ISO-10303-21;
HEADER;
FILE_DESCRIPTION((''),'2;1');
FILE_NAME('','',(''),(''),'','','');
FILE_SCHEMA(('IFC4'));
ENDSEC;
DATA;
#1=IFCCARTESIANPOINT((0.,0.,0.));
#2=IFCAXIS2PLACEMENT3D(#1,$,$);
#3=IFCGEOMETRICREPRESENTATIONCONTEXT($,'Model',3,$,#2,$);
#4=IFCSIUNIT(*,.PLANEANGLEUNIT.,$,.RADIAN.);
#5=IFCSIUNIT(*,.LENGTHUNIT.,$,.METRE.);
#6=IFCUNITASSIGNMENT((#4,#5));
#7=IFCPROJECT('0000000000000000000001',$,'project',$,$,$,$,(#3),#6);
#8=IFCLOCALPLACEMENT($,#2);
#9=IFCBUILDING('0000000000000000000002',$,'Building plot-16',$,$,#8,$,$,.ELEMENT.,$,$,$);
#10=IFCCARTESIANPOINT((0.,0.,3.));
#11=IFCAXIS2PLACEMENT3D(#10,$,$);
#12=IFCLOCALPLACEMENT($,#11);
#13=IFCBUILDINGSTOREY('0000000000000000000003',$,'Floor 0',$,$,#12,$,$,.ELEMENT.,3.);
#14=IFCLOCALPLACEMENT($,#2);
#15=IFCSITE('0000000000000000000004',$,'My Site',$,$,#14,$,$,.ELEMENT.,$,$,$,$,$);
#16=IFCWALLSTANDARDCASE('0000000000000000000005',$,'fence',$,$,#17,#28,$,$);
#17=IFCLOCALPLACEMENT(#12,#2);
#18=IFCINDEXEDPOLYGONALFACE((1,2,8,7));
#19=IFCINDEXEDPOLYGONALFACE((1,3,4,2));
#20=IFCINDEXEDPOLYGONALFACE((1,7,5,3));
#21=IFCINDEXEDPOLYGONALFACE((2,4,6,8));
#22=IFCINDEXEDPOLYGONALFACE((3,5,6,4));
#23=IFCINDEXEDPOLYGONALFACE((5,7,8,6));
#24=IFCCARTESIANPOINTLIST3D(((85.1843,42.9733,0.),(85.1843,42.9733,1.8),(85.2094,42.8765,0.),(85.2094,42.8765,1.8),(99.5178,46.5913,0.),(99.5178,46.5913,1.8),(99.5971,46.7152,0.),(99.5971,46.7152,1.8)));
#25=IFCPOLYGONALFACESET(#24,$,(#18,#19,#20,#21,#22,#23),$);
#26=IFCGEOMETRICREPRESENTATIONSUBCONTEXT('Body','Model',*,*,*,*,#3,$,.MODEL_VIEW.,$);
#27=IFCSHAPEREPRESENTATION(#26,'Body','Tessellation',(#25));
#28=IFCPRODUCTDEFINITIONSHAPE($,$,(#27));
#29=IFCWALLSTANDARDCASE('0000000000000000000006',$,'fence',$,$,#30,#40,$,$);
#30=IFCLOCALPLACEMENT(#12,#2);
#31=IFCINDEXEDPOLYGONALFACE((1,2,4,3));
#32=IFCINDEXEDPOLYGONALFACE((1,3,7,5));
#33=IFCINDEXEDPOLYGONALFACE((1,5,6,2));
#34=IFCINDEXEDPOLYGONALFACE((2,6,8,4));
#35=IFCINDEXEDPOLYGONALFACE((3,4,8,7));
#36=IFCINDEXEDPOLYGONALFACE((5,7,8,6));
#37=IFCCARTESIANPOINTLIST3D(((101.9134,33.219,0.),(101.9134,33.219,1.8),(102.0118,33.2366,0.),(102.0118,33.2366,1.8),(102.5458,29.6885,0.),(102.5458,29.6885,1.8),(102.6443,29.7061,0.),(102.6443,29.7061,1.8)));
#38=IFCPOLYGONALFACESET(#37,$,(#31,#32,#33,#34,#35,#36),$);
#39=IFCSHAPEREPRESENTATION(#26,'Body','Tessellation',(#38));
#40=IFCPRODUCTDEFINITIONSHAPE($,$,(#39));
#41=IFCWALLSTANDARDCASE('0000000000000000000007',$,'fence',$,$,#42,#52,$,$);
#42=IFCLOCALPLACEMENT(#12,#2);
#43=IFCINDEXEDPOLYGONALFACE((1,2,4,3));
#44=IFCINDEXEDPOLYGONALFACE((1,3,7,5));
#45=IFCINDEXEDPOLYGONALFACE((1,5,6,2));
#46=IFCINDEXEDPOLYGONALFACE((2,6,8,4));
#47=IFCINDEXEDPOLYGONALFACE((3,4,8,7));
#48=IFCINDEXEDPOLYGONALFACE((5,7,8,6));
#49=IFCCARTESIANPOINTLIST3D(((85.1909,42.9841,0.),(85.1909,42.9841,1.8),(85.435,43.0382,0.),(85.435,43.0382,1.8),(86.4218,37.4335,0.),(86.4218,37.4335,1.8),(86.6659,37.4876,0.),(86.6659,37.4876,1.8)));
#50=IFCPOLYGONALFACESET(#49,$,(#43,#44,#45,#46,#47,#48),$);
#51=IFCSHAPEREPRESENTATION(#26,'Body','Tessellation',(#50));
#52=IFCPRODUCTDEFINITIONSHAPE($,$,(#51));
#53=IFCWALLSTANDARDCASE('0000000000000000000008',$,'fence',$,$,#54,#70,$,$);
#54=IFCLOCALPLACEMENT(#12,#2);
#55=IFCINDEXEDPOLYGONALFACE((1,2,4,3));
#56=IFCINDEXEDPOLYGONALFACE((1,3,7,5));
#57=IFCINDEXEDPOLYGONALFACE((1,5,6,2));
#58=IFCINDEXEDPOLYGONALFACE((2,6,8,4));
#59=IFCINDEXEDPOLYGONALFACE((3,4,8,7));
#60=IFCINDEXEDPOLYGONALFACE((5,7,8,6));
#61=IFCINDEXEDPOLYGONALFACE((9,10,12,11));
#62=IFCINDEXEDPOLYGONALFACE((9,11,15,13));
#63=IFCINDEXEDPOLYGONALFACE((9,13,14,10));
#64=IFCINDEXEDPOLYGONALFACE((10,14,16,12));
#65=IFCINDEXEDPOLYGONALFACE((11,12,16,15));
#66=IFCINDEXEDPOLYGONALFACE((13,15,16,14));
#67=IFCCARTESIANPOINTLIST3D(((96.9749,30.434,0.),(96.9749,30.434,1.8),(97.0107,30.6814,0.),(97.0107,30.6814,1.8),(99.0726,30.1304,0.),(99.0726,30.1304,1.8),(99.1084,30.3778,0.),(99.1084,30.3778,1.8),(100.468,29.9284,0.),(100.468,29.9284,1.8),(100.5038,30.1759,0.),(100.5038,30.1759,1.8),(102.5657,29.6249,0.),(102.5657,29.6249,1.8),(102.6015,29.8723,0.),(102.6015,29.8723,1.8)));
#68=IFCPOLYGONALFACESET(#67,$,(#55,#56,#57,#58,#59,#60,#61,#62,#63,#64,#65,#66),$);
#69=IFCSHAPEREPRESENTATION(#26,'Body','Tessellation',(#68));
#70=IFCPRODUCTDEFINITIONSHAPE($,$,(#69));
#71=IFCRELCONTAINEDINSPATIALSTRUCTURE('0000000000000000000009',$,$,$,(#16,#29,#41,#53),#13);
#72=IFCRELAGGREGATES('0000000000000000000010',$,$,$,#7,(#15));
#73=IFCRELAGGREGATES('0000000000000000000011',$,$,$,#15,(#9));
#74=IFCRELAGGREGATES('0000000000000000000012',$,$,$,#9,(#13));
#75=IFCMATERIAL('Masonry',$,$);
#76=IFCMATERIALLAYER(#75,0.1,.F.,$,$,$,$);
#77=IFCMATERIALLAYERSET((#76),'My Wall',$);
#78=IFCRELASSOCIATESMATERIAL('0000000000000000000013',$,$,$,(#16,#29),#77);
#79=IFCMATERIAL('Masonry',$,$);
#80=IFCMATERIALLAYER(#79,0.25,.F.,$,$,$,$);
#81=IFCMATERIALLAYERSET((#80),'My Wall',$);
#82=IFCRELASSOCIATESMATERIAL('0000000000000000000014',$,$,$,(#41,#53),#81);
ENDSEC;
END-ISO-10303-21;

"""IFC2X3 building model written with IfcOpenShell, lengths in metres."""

from ifc_helpers import new_model, si_unit, frame, origin, place, context, subcontext, project, spatial, polyline, outline, extrude, material, layer, layer_set, layer_usage, element, save


model = new_model("IFC2X3")

# Units and contexts
model_context = context("Model", 3, world=origin())
body_context = subcontext(model_context, "Body", "Model", "MODEL_VIEW")
ifc_project = project(units=[si_unit("PLANEANGLEUNIT", "RADIAN"), si_unit("LENGTHUNIT", "METRE")], contexts=[model_context])

# Site, building, storey
site_placement = place(None, origin())
site = spatial("IfcSite", under=ifc_project, at=site_placement, Name="My Site", CompositionType="ELEMENT")
building_placement = place(None, origin())
building = spatial("IfcBuilding", under=site, at=building_placement, Name="Building plot-16", CompositionType="ELEMENT")
storey_placement = place(None, frame((0.0, 0.0, 3.0)))
storey = spatial("IfcBuildingStorey", under=building, at=storey_placement, Name="Floor 0", CompositionType="ELEMENT", Elevation=3.0)

# Walls
ifc_material_1 = material(Name="Masonry")
ifc_layer_1 = layer(ifc_material_1, 0.1, ventilated=False)
ifc_layer_set_1 = layer_set([ifc_layer_1], Name="My Wall")
ifc_layer_usage_1 = layer_usage(ifc_layer_set_1, "AXIS2", "NEGATIVE", -0.15)
wall_1_placement = place(storey_placement, origin())
element("IfcWallStandardCase", 1, at=wall_1_placement, inside=storey, material=ifc_layer_usage_1, Name="fence", context=body_context, shape_type="SweptSolid", body=[
    extrude(outline(polyline([(99.5178, 46.5913), (99.5971, 46.7152), (85.1843, 42.9733), (85.2094, 42.8765), (99.5178, 46.5913)])), origin(), (0.0, 0.0, 1.0), 1.8),
])
wall_2_placement = place(storey_placement, origin())
element("IfcWallStandardCase", 2, at=wall_2_placement, inside=storey, material=ifc_layer_usage_1, Name="fence", context=body_context, shape_type="SweptSolid", body=[
    extrude(outline(polyline([(102.5458, 29.6885), (102.6443, 29.7061), (102.0118, 33.2366), (101.9134, 33.219), (102.5458, 29.6885)])), origin(), (0.0, 0.0, 1.0), 1.8),
])
ifc_material_2 = material(Name="Masonry")
ifc_layer_2 = layer(ifc_material_2, 0.25, ventilated=False)
ifc_layer_set_2 = layer_set([ifc_layer_2], Name="My Wall")
ifc_layer_usage_2 = layer_usage(ifc_layer_set_2, "AXIS2", "NEGATIVE", 0.0)
wall_3_placement = place(storey_placement, origin())
element("IfcWallStandardCase", 3, at=wall_3_placement, inside=storey, material=ifc_layer_usage_2, Name="fence", context=body_context, shape_type="SweptSolid", body=[
    extrude(outline(polyline([(85.435, 43.0382), (85.1909, 42.9841), (86.4218, 37.4335), (86.6659, 37.4876), (85.435, 43.0382)])), origin(), (0.0, 0.0, 1.0), 1.8),
])

# Wall, opening
wall_4_placement = place(storey_placement, origin())
wall_4 = element("IfcWallStandardCase", 4, at=wall_4_placement, inside=storey, material=ifc_layer_usage_2, Name="fence", context=body_context, shape_type="SweptSolid", body=[
    extrude(outline(polyline([(97.0107, 30.6814), (96.9749, 30.434), (102.5657, 29.6249), (102.6015, 29.8723), (97.0107, 30.6814)])), origin(), (0.0, 0.0, 1.0), 1.8),
])
opening_1_placement = place(storey_placement, origin())
element("IfcOpeningElement", 5, at=opening_1_placement, cuts=wall_4, ObjectType="Opening", context=body_context, shape_type="SweptSolid", body=[
    extrude(outline(polyline([(99.0726, 30.1304), (100.468, 29.9284), (100.5038, 30.1759), (99.1084, 30.3778), (99.0726, 30.1304)])), origin(), (0.0, 0.0, 1.0), 2.08),
])

save(model, "model.ifc")
